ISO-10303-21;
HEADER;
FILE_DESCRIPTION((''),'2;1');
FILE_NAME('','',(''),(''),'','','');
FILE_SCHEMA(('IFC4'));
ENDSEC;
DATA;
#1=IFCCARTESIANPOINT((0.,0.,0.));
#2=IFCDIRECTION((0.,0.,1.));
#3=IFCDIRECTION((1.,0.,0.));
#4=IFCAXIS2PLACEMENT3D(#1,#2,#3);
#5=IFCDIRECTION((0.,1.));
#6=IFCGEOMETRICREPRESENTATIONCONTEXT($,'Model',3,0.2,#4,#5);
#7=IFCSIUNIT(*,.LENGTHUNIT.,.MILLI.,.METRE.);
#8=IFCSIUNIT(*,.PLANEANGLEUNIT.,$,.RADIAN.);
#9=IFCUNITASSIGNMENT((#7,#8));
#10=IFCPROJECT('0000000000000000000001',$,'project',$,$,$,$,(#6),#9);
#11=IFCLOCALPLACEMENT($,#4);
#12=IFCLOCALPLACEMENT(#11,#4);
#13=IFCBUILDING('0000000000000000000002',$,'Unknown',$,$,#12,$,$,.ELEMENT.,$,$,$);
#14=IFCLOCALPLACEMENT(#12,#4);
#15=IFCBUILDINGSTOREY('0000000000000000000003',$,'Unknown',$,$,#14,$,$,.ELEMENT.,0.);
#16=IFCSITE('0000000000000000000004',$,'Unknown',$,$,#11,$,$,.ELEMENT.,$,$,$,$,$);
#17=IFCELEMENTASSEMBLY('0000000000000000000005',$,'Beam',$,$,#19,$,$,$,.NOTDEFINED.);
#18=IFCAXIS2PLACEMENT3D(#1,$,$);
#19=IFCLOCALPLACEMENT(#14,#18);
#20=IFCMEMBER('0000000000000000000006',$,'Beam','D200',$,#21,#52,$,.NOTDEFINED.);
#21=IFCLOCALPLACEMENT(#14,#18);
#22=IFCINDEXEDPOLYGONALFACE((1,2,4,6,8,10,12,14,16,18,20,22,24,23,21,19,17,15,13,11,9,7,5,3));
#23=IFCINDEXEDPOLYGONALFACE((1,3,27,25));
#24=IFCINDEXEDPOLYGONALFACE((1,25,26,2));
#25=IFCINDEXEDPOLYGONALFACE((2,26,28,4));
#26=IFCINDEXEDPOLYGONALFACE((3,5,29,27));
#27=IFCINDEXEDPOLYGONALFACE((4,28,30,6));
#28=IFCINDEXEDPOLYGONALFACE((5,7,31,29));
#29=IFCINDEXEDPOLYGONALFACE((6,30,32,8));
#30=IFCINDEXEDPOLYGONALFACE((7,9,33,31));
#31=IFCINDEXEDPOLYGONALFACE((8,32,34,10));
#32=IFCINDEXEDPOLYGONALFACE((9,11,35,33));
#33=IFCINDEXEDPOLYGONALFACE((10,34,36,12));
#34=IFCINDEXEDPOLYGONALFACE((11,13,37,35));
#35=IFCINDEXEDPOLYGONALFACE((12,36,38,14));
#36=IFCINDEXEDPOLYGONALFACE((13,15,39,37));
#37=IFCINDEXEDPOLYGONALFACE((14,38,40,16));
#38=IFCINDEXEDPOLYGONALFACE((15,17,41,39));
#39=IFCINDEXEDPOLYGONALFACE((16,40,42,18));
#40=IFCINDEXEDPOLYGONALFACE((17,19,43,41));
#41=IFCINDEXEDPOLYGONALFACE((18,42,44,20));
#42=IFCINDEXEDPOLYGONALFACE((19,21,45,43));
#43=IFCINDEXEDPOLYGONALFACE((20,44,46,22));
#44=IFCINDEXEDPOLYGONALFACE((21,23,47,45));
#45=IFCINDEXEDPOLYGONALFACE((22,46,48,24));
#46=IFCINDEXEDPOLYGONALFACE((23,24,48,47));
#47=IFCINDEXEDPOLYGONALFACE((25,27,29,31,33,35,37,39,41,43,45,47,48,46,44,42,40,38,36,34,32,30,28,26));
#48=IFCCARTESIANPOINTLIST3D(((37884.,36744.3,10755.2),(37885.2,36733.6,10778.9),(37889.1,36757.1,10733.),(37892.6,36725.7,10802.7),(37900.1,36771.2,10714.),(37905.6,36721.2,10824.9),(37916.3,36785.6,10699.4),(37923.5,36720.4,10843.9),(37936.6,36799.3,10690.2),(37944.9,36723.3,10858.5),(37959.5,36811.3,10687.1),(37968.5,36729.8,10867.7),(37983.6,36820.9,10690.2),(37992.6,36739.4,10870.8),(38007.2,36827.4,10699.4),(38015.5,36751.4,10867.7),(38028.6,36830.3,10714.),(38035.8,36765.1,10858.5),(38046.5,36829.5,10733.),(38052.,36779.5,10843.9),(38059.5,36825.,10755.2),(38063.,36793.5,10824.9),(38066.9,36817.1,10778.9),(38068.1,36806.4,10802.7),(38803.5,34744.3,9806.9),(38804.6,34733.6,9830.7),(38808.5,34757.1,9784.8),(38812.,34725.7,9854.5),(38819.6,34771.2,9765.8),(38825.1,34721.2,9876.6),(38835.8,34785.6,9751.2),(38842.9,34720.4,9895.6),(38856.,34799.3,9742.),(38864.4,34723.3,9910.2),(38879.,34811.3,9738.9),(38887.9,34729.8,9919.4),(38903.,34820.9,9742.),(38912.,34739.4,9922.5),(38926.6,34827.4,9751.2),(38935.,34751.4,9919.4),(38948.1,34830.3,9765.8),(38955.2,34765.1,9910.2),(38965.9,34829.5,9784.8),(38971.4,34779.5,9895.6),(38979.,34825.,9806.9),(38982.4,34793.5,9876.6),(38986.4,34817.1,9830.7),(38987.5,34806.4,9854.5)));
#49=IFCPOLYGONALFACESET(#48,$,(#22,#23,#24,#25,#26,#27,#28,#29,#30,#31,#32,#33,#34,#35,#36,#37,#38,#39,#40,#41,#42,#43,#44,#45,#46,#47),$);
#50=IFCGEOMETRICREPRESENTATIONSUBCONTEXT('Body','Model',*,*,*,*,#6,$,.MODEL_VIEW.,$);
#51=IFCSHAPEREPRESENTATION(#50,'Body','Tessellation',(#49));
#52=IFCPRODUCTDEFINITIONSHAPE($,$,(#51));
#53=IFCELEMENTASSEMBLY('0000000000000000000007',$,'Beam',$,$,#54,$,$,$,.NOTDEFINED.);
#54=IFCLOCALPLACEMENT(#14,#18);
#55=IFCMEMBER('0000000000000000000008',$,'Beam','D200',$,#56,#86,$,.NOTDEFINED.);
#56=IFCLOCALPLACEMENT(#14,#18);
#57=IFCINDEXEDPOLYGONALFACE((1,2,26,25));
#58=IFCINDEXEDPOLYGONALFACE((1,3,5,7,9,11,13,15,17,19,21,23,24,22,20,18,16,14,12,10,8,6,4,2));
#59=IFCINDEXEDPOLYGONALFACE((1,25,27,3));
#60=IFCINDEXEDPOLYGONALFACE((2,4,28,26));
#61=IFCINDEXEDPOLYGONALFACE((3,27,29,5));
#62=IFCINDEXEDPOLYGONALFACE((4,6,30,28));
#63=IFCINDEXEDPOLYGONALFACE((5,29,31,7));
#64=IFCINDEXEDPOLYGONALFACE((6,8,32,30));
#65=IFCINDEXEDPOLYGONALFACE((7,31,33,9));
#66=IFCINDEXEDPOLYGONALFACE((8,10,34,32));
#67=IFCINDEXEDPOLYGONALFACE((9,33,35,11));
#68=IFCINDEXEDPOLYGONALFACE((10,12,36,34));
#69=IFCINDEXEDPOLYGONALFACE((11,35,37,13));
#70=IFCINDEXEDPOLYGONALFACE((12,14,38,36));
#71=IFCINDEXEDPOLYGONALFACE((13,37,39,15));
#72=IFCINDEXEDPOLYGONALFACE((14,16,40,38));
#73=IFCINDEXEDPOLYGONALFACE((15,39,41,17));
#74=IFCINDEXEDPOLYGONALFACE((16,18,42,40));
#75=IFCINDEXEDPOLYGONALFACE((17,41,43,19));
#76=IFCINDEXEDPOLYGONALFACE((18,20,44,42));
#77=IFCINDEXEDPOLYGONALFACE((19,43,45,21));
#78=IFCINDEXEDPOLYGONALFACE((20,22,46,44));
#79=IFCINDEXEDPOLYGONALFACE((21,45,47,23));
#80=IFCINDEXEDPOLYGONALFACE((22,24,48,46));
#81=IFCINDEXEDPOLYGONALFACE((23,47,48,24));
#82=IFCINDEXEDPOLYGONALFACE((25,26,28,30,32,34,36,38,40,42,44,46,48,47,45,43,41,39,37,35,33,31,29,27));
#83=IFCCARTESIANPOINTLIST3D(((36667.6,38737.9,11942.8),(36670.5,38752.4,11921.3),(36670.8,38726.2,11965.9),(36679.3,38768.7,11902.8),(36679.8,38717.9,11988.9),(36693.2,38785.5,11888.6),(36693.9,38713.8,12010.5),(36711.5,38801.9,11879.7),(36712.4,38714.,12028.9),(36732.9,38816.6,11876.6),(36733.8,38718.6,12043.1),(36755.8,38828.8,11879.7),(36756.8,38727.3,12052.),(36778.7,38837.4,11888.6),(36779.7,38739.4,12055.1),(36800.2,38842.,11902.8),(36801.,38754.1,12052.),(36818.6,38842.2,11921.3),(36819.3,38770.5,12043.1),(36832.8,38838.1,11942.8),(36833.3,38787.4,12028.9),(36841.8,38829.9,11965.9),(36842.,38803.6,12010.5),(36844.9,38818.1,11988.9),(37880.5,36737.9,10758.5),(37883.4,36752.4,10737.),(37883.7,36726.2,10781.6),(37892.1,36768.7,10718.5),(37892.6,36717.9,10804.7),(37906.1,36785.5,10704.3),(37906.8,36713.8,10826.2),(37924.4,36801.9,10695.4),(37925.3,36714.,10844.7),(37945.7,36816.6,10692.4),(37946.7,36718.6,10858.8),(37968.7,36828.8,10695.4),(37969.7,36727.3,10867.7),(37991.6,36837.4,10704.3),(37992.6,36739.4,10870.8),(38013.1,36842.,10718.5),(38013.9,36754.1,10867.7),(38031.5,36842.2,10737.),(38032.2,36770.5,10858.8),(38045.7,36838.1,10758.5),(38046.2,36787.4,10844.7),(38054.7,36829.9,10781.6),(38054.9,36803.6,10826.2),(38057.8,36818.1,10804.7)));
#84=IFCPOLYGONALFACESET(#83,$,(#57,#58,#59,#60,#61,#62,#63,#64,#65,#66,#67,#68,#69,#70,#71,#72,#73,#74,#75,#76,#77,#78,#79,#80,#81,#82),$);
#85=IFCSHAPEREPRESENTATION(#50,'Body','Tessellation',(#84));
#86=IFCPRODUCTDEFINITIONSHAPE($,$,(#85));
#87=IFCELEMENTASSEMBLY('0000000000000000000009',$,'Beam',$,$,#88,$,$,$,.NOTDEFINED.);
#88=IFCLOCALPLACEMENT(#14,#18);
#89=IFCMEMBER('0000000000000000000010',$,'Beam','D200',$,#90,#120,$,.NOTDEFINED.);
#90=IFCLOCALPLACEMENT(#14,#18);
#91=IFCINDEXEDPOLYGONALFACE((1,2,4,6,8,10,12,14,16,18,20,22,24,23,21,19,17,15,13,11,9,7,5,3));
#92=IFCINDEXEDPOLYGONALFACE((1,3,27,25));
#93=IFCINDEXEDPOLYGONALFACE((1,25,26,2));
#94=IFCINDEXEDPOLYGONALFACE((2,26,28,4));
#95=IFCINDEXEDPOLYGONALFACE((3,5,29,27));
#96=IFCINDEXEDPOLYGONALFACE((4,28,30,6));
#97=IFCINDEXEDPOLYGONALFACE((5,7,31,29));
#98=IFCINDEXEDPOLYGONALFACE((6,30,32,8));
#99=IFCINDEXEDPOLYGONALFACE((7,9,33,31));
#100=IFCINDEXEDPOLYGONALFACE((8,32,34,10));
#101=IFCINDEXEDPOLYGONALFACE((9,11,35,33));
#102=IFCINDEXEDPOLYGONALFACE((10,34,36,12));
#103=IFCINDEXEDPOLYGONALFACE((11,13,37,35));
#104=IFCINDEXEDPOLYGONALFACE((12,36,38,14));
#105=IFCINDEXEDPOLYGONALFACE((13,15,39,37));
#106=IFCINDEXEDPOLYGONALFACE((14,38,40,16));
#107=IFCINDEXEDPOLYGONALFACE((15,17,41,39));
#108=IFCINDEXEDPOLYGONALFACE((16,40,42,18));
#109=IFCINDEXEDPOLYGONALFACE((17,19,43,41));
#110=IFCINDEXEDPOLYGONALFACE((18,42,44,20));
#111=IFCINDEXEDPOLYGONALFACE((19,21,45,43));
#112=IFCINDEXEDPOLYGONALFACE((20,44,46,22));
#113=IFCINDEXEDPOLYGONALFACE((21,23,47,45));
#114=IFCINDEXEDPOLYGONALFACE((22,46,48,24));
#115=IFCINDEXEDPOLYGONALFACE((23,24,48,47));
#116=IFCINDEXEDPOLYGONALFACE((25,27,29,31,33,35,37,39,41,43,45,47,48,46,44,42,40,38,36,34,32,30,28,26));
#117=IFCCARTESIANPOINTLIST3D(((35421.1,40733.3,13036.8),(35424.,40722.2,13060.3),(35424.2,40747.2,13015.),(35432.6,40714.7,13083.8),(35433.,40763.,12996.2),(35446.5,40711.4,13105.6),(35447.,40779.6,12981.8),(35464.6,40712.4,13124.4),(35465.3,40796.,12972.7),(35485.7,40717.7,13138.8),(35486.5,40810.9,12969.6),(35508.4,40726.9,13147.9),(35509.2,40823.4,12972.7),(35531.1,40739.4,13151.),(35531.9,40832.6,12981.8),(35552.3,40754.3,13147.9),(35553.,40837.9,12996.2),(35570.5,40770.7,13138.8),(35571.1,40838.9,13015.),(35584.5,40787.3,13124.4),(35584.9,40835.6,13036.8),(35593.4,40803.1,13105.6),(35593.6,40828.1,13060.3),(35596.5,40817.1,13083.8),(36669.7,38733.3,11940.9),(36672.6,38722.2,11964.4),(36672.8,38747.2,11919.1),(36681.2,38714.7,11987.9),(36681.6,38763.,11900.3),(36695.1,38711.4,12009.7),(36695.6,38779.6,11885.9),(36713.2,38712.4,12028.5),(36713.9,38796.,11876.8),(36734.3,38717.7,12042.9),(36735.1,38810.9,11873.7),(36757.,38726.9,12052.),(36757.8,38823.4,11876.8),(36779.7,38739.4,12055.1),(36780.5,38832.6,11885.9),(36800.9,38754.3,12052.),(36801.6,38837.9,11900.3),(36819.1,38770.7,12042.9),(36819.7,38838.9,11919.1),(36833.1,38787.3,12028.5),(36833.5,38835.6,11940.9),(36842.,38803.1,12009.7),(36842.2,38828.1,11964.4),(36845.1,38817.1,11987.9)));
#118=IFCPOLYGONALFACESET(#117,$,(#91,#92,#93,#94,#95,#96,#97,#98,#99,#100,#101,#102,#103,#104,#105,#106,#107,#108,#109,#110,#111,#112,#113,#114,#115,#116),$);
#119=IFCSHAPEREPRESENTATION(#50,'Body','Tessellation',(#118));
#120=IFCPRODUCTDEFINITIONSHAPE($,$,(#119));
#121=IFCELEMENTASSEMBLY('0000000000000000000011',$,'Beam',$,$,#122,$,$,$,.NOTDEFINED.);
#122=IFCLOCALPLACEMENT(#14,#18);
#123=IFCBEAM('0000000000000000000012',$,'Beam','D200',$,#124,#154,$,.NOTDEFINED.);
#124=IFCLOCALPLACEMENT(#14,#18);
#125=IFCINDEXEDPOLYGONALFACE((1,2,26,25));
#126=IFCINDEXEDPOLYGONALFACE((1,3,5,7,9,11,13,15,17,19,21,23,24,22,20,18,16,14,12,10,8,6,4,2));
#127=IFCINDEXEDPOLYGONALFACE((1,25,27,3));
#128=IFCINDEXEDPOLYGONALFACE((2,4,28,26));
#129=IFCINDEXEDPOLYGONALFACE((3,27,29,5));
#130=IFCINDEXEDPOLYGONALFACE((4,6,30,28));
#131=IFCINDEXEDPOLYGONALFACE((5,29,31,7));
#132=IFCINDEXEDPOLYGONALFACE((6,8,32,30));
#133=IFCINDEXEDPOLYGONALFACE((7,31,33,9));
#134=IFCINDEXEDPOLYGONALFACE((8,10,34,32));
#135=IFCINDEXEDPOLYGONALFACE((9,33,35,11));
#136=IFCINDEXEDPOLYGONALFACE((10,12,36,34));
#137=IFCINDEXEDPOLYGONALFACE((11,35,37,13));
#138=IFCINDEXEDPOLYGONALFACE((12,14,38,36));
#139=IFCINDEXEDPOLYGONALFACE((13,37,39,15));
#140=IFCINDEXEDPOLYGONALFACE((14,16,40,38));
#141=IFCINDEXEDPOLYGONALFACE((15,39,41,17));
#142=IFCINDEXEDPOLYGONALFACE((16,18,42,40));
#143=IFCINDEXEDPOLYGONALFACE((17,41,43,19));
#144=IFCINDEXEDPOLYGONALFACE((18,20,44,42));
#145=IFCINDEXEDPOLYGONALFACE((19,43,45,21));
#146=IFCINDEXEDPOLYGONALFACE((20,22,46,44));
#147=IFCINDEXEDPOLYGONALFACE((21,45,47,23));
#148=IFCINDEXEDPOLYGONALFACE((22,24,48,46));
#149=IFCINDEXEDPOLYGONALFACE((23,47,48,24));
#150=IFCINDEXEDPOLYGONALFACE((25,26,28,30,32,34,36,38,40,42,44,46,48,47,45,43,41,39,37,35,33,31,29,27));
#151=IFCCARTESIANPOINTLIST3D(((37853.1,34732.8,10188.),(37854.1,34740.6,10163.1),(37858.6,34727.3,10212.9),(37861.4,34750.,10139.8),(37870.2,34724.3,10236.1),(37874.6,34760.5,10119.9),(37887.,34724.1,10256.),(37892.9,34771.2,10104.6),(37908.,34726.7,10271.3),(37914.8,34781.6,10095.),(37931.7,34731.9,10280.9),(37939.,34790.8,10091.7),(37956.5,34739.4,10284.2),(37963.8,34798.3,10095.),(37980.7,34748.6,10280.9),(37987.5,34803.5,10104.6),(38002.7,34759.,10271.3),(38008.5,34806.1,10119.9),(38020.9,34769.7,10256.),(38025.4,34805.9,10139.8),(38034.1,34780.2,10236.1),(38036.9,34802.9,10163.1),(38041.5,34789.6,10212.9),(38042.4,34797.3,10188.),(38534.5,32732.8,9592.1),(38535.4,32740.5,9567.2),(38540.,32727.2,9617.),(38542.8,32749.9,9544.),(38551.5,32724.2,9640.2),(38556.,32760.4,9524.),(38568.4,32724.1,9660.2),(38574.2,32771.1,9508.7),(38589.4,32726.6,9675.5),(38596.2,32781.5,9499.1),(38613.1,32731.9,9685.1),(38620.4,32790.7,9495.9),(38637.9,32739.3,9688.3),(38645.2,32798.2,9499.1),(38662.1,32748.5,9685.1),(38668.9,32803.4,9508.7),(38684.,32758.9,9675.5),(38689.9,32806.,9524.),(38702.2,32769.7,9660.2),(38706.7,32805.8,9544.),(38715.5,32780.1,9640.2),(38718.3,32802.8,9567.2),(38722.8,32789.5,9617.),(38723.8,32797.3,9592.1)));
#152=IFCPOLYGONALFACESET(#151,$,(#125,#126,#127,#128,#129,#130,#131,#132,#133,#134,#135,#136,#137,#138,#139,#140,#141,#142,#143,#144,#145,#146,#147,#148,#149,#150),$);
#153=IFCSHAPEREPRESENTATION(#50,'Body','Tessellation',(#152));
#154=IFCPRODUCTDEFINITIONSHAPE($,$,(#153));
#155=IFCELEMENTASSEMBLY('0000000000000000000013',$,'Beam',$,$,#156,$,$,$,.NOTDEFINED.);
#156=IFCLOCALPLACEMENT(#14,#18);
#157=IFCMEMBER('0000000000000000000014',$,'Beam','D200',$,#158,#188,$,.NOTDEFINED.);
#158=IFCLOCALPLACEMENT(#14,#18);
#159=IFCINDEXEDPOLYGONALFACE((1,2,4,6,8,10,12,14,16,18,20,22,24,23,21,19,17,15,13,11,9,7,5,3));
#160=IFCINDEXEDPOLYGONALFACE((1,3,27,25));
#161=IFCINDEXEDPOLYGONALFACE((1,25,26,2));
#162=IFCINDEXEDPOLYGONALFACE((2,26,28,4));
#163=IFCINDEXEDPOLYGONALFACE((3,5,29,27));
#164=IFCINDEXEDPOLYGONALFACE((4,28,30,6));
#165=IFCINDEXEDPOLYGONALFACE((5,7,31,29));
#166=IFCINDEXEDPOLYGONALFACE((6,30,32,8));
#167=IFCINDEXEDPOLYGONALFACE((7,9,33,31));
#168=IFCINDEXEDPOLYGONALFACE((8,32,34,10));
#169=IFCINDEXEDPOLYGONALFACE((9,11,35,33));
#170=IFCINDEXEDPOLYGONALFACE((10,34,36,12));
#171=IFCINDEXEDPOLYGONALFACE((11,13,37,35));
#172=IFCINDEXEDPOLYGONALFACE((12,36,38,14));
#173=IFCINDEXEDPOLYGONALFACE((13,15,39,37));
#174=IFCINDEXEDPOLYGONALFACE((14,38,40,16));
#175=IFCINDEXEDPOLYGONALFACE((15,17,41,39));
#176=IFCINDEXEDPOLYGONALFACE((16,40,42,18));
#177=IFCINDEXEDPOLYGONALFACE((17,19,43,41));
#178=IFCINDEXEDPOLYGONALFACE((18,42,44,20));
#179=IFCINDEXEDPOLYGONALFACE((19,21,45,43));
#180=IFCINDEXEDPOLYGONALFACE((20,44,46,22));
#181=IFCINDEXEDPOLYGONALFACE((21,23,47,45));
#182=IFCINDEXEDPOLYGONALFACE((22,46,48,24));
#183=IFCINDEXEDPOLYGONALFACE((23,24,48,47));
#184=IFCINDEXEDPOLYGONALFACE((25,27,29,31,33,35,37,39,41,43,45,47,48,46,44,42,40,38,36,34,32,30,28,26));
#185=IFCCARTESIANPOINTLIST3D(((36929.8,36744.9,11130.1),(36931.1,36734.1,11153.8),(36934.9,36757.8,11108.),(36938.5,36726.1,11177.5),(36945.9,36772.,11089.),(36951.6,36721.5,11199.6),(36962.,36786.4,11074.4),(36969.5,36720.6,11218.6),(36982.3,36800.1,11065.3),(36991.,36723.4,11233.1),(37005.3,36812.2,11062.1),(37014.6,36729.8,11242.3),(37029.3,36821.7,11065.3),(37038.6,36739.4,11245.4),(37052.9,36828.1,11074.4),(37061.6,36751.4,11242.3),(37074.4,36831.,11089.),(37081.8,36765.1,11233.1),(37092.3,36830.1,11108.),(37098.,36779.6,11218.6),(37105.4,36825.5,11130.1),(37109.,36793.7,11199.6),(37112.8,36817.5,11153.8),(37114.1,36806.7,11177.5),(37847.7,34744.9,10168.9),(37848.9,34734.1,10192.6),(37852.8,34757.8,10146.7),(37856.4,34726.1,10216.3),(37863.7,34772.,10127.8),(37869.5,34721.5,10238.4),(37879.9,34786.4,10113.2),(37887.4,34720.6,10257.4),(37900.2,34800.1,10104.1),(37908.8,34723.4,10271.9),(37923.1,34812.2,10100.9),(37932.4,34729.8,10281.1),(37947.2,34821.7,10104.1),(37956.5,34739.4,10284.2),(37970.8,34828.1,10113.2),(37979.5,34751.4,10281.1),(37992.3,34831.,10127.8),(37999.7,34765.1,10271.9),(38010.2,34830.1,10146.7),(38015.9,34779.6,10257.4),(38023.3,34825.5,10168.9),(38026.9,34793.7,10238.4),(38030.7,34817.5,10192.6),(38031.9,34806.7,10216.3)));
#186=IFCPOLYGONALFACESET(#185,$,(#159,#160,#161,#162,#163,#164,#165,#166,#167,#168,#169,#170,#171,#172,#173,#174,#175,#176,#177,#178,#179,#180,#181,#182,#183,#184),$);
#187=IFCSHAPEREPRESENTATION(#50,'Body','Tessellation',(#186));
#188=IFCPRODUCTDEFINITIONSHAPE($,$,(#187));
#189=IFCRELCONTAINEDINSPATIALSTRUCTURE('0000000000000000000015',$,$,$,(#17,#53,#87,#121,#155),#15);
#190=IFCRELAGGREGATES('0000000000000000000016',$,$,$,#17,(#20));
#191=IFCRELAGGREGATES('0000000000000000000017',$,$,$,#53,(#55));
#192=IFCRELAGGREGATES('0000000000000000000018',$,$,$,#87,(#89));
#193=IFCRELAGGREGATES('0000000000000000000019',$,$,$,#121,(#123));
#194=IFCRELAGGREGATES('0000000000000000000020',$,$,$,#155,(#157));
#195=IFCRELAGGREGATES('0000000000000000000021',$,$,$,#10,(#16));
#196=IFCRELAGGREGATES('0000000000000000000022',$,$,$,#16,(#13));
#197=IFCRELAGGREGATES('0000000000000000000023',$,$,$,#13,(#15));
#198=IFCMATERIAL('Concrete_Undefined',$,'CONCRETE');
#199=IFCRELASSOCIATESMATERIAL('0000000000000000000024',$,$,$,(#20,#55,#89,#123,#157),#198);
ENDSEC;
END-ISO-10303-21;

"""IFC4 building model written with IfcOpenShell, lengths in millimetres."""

from ifc_helpers import new_model, si_unit, direction, frame, origin_with_axes, place, context, subcontext, project, spatial, line, indexed_curve, outline, extrude, material, element, aggregate, save


model = new_model("IFC4")

# Units and contexts
model_context = context("Model", 3, precision=0.2, world=origin_with_axes(), true_north=direction((0.0, 1.0)))
body_context = subcontext(model_context, "Body", "Model", "MODEL_VIEW")
ifc_project = project(units=[si_unit("LENGTHUNIT", "METRE", prefix="MILLI"), si_unit("PLANEANGLEUNIT", "RADIAN")], contexts=[model_context])

# Site, building, storey
site_placement = place(None, origin_with_axes())
site = spatial("IfcSite", under=ifc_project, at=site_placement, Name="Unknown", CompositionType="ELEMENT")
building_placement = place(site_placement, origin_with_axes())
building = spatial("IfcBuilding", under=site, at=building_placement, Name="Unknown", CompositionType="ELEMENT")
storey_placement = place(building_placement, origin_with_axes())
storey = spatial("IfcBuildingStorey", under=building, at=storey_placement, Name="Unknown", CompositionType="ELEMENT", Elevation=0.0)

# Shared definitions
ifc_material = material(Name="Concrete_Undefined", Category="CONCRETE")

# Element assemblies, members
assembly_1_placement = place(storey_placement, frame((37976.1, 36775.3, 10778.9), z_axis=(-0.908589, -0.417692, 0.0), x_axis=(0.383612, -0.834456, -0.395632)))
assembly_1 = element("IfcElementAssembly", 1, at=assembly_1_placement, inside=storey, Name="Beam", PredefinedType="NOTDEFINED")
member_1_placement = place(assembly_1_placement, origin_with_axes())
member_1 = element("IfcMember", 2, at=member_1_placement, material=ifc_material, Name="Beam", Description="D200", PredefinedType="NOTDEFINED", context=body_context, shape_type="SolidModel", body=[
    extrude(outline(indexed_curve([(100.0, 0.0), (96.6, 25.9), (86.6, 50.0), (70.7, 70.7), (50.0, 86.6), (25.9, 96.6), (0.0, 100.0), (-25.9, 96.6), (-50.0, 86.6), (-70.7, 70.7), (-86.6, 50.0), (-96.6, 25.9), (-100.0, 0.0), (-96.6, -25.9), (-86.6, -50.0), (-70.7, -70.7), (-50.0, -86.6), (-25.9, -96.6), (0.0, -100.0), (25.9, -96.6), (50.0, -86.6), (70.7, -70.7), (86.6, -50.0), (96.6, -25.9)], segments=[line(1, 2, 3, 4, 5, 6, 7, 8, 9, 10, 11, 12, 13, 14, 15, 16, 17, 18, 19, 20, 21, 22, 23, 24, 1)])), frame((0.0, 0.0, 0.0), z_axis=(-1.0, 0.0, 0.0), x_axis=(0.0, 0.0, 1.0)), (0.0, 0.0, -1.0), 2396.8),
])
aggregate(assembly_1, [member_1])
assembly_2_placement = place(storey_placement, frame((36756.3, 38778.0, 11965.9), z_axis=(-0.855053, -0.51854, 0.0), x_axis=(0.462622, -0.762846, -0.451715)))
assembly_2 = element("IfcElementAssembly", 3, at=assembly_2_placement, inside=storey, Name="Beam", PredefinedType="NOTDEFINED")
member_2_placement = place(assembly_2_placement, origin_with_axes())
member_2 = element("IfcMember", 4, at=member_2_placement, material=ifc_material, Name="Beam", Description="D200", PredefinedType="NOTDEFINED", context=body_context, shape_type="SolidModel", body=[
    extrude(outline(indexed_curve([(100.0, 0.0), (96.6, 25.9), (86.6, 50.0), (70.7, 70.7), (50.0, 86.6), (25.9, 96.6), (0.0, 100.0), (-25.9, 96.6), (-50.0, 86.6), (-70.7, 70.7), (-86.6, 50.0), (-96.6, 25.9), (-100.0, 0.0), (-96.6, -25.9), (-86.6, -50.0), (-70.7, -70.7), (-50.0, -86.6), (-25.9, -96.6), (0.0, -100.0), (25.9, -96.6), (50.0, -86.6), (70.7, -70.7), (86.6, -50.0), (96.6, -25.9)], segments=[line(1, 2, 3, 4, 5, 6, 7, 8, 9, 10, 11, 12, 13, 14, 15, 16, 17, 18, 19, 20, 21, 22, 23, 24, 1)])), frame((0.0, 0.0, 0.0), z_axis=(-1.0, 0.0, 0.0), x_axis=(0.0, 0.0, 1.0)), (0.0, 0.0, -1.0), 2621.8),
])
aggregate(assembly_2, [member_2])
assembly_3_placement = place(storey_placement, frame((35508.8, 40775.2, 13060.3), z_axis=(-0.848265, -0.529572, 0.0), x_axis=(0.480231, -0.76923, -0.421502)))
assembly_3 = element("IfcElementAssembly", 5, at=assembly_3_placement, inside=storey, Name="Beam", PredefinedType="NOTDEFINED")
member_3_placement = place(assembly_3_placement, origin_with_axes())
member_3 = element("IfcMember", 6, at=member_3_placement, material=ifc_material, Name="Beam", Description="D200", PredefinedType="NOTDEFINED", context=body_context, shape_type="SolidModel", body=[
    extrude(outline(indexed_curve([(100.0, 0.0), (96.6, 25.9), (86.6, 50.0), (70.7, 70.7), (50.0, 86.6), (25.9, 96.6), (0.0, 100.0), (-25.9, 96.6), (-50.0, 86.6), (-70.7, 70.7), (-86.6, 50.0), (-96.6, 25.9), (-100.0, 0.0), (-96.6, -25.9), (-86.6, -50.0), (-70.7, -70.7), (-50.0, -86.6), (-25.9, -96.6), (0.0, -100.0), (25.9, -96.6), (50.0, -86.6), (70.7, -70.7), (86.6, -50.0), (96.6, -25.9)], segments=[line(1, 2, 3, 4, 5, 6, 7, 8, 9, 10, 11, 12, 13, 14, 15, 16, 17, 18, 19, 20, 21, 22, 23, 24, 1)])), frame((0.0, 0.0, 0.0), z_axis=(-1.0, 0.0, 0.0), x_axis=(0.0, 0.0, 1.0)), (0.0, 0.0, -1.0), 2600.0),
])
aggregate(assembly_3, [member_3])

# Element assembly, beam
assembly_4_placement = place(storey_placement, frame((37947.8, 34765.1, 10188.0), z_axis=(-0.94658, -0.322469, 0.0), x_axis=(0.310364, -0.911047, -0.271419)))
assembly_4 = element("IfcElementAssembly", 7, at=assembly_4_placement, inside=storey, Name="Beam", PredefinedType="NOTDEFINED")
beam_1_placement = place(assembly_4_placement, origin_with_axes())
beam_1 = element("IfcBeam", 8, at=beam_1_placement, material=ifc_material, Name="Beam", Description="D200", PredefinedType="NOTDEFINED", context=body_context, shape_type="SolidModel", body=[
    extrude(outline(indexed_curve([(100.0, 0.0), (96.6, 25.9), (86.6, 50.0), (70.7, 70.7), (50.0, 86.6), (25.9, 96.6), (0.0, 100.0), (-25.9, 96.6), (-50.0, 86.6), (-70.7, 70.7), (-86.6, 50.0), (-96.6, 25.9), (-100.0, 0.0), (-96.6, -25.9), (-86.6, -50.0), (-70.7, -70.7), (-50.0, -86.6), (-25.9, -96.6), (0.0, -100.0), (25.9, -96.6), (50.0, -86.6), (70.7, -70.7), (86.6, -50.0), (96.6, -25.9)], segments=[line(1, 2, 3, 4, 5, 6, 7, 8, 9, 10, 11, 12, 13, 14, 15, 16, 17, 18, 19, 20, 21, 22, 23, 24, 1)])), frame((0.0, 0.0, 0.0), z_axis=(-1.0, 0.0, 0.0), x_axis=(0.0, 0.0, 1.0)), (0.0, 0.0, -1.0), 2195.4),
])
aggregate(assembly_4, [beam_1])

# Element assembly, member
assembly_5_placement = place(storey_placement, frame((37021.9, 36775.8, 11153.8), z_axis=(-0.908857, -0.417107, 0.0), x_axis=(0.382234, -0.83287, -0.400281)))
assembly_5 = element("IfcElementAssembly", 9, at=assembly_5_placement, inside=storey, Name="Beam", PredefinedType="NOTDEFINED")
member_4_placement = place(assembly_5_placement, origin_with_axes())
member_4 = element("IfcMember", 10, at=member_4_placement, material=ifc_material, Name="Beam", Description="D200", PredefinedType="NOTDEFINED", context=body_context, shape_type="SolidModel", body=[
    extrude(outline(indexed_curve([(100.0, 0.0), (96.6, 25.9), (86.6, 50.0), (70.7, 70.7), (50.0, 86.6), (25.9, 96.6), (0.0, 100.0), (-25.9, 96.6), (-50.0, 86.6), (-70.7, 70.7), (-86.6, 50.0), (-96.6, 25.9), (-100.0, 0.0), (-96.6, -25.9), (-86.6, -50.0), (-70.7, -70.7), (-50.0, -86.6), (-25.9, -96.6), (0.0, -100.0), (25.9, -96.6), (50.0, -86.6), (70.7, -70.7), (86.6, -50.0), (96.6, -25.9)], segments=[line(1, 2, 3, 4, 5, 6, 7, 8, 9, 10, 11, 12, 13, 14, 15, 16, 17, 18, 19, 20, 21, 22, 23, 24, 1)])), frame((0.0, 0.0, 0.0), z_axis=(-1.0, 0.0, 0.0), x_axis=(0.0, 0.0, 1.0)), (0.0, 0.0, -1.0), 2401.3),
])
aggregate(assembly_5, [member_4])

save(model, "model.ifc")
